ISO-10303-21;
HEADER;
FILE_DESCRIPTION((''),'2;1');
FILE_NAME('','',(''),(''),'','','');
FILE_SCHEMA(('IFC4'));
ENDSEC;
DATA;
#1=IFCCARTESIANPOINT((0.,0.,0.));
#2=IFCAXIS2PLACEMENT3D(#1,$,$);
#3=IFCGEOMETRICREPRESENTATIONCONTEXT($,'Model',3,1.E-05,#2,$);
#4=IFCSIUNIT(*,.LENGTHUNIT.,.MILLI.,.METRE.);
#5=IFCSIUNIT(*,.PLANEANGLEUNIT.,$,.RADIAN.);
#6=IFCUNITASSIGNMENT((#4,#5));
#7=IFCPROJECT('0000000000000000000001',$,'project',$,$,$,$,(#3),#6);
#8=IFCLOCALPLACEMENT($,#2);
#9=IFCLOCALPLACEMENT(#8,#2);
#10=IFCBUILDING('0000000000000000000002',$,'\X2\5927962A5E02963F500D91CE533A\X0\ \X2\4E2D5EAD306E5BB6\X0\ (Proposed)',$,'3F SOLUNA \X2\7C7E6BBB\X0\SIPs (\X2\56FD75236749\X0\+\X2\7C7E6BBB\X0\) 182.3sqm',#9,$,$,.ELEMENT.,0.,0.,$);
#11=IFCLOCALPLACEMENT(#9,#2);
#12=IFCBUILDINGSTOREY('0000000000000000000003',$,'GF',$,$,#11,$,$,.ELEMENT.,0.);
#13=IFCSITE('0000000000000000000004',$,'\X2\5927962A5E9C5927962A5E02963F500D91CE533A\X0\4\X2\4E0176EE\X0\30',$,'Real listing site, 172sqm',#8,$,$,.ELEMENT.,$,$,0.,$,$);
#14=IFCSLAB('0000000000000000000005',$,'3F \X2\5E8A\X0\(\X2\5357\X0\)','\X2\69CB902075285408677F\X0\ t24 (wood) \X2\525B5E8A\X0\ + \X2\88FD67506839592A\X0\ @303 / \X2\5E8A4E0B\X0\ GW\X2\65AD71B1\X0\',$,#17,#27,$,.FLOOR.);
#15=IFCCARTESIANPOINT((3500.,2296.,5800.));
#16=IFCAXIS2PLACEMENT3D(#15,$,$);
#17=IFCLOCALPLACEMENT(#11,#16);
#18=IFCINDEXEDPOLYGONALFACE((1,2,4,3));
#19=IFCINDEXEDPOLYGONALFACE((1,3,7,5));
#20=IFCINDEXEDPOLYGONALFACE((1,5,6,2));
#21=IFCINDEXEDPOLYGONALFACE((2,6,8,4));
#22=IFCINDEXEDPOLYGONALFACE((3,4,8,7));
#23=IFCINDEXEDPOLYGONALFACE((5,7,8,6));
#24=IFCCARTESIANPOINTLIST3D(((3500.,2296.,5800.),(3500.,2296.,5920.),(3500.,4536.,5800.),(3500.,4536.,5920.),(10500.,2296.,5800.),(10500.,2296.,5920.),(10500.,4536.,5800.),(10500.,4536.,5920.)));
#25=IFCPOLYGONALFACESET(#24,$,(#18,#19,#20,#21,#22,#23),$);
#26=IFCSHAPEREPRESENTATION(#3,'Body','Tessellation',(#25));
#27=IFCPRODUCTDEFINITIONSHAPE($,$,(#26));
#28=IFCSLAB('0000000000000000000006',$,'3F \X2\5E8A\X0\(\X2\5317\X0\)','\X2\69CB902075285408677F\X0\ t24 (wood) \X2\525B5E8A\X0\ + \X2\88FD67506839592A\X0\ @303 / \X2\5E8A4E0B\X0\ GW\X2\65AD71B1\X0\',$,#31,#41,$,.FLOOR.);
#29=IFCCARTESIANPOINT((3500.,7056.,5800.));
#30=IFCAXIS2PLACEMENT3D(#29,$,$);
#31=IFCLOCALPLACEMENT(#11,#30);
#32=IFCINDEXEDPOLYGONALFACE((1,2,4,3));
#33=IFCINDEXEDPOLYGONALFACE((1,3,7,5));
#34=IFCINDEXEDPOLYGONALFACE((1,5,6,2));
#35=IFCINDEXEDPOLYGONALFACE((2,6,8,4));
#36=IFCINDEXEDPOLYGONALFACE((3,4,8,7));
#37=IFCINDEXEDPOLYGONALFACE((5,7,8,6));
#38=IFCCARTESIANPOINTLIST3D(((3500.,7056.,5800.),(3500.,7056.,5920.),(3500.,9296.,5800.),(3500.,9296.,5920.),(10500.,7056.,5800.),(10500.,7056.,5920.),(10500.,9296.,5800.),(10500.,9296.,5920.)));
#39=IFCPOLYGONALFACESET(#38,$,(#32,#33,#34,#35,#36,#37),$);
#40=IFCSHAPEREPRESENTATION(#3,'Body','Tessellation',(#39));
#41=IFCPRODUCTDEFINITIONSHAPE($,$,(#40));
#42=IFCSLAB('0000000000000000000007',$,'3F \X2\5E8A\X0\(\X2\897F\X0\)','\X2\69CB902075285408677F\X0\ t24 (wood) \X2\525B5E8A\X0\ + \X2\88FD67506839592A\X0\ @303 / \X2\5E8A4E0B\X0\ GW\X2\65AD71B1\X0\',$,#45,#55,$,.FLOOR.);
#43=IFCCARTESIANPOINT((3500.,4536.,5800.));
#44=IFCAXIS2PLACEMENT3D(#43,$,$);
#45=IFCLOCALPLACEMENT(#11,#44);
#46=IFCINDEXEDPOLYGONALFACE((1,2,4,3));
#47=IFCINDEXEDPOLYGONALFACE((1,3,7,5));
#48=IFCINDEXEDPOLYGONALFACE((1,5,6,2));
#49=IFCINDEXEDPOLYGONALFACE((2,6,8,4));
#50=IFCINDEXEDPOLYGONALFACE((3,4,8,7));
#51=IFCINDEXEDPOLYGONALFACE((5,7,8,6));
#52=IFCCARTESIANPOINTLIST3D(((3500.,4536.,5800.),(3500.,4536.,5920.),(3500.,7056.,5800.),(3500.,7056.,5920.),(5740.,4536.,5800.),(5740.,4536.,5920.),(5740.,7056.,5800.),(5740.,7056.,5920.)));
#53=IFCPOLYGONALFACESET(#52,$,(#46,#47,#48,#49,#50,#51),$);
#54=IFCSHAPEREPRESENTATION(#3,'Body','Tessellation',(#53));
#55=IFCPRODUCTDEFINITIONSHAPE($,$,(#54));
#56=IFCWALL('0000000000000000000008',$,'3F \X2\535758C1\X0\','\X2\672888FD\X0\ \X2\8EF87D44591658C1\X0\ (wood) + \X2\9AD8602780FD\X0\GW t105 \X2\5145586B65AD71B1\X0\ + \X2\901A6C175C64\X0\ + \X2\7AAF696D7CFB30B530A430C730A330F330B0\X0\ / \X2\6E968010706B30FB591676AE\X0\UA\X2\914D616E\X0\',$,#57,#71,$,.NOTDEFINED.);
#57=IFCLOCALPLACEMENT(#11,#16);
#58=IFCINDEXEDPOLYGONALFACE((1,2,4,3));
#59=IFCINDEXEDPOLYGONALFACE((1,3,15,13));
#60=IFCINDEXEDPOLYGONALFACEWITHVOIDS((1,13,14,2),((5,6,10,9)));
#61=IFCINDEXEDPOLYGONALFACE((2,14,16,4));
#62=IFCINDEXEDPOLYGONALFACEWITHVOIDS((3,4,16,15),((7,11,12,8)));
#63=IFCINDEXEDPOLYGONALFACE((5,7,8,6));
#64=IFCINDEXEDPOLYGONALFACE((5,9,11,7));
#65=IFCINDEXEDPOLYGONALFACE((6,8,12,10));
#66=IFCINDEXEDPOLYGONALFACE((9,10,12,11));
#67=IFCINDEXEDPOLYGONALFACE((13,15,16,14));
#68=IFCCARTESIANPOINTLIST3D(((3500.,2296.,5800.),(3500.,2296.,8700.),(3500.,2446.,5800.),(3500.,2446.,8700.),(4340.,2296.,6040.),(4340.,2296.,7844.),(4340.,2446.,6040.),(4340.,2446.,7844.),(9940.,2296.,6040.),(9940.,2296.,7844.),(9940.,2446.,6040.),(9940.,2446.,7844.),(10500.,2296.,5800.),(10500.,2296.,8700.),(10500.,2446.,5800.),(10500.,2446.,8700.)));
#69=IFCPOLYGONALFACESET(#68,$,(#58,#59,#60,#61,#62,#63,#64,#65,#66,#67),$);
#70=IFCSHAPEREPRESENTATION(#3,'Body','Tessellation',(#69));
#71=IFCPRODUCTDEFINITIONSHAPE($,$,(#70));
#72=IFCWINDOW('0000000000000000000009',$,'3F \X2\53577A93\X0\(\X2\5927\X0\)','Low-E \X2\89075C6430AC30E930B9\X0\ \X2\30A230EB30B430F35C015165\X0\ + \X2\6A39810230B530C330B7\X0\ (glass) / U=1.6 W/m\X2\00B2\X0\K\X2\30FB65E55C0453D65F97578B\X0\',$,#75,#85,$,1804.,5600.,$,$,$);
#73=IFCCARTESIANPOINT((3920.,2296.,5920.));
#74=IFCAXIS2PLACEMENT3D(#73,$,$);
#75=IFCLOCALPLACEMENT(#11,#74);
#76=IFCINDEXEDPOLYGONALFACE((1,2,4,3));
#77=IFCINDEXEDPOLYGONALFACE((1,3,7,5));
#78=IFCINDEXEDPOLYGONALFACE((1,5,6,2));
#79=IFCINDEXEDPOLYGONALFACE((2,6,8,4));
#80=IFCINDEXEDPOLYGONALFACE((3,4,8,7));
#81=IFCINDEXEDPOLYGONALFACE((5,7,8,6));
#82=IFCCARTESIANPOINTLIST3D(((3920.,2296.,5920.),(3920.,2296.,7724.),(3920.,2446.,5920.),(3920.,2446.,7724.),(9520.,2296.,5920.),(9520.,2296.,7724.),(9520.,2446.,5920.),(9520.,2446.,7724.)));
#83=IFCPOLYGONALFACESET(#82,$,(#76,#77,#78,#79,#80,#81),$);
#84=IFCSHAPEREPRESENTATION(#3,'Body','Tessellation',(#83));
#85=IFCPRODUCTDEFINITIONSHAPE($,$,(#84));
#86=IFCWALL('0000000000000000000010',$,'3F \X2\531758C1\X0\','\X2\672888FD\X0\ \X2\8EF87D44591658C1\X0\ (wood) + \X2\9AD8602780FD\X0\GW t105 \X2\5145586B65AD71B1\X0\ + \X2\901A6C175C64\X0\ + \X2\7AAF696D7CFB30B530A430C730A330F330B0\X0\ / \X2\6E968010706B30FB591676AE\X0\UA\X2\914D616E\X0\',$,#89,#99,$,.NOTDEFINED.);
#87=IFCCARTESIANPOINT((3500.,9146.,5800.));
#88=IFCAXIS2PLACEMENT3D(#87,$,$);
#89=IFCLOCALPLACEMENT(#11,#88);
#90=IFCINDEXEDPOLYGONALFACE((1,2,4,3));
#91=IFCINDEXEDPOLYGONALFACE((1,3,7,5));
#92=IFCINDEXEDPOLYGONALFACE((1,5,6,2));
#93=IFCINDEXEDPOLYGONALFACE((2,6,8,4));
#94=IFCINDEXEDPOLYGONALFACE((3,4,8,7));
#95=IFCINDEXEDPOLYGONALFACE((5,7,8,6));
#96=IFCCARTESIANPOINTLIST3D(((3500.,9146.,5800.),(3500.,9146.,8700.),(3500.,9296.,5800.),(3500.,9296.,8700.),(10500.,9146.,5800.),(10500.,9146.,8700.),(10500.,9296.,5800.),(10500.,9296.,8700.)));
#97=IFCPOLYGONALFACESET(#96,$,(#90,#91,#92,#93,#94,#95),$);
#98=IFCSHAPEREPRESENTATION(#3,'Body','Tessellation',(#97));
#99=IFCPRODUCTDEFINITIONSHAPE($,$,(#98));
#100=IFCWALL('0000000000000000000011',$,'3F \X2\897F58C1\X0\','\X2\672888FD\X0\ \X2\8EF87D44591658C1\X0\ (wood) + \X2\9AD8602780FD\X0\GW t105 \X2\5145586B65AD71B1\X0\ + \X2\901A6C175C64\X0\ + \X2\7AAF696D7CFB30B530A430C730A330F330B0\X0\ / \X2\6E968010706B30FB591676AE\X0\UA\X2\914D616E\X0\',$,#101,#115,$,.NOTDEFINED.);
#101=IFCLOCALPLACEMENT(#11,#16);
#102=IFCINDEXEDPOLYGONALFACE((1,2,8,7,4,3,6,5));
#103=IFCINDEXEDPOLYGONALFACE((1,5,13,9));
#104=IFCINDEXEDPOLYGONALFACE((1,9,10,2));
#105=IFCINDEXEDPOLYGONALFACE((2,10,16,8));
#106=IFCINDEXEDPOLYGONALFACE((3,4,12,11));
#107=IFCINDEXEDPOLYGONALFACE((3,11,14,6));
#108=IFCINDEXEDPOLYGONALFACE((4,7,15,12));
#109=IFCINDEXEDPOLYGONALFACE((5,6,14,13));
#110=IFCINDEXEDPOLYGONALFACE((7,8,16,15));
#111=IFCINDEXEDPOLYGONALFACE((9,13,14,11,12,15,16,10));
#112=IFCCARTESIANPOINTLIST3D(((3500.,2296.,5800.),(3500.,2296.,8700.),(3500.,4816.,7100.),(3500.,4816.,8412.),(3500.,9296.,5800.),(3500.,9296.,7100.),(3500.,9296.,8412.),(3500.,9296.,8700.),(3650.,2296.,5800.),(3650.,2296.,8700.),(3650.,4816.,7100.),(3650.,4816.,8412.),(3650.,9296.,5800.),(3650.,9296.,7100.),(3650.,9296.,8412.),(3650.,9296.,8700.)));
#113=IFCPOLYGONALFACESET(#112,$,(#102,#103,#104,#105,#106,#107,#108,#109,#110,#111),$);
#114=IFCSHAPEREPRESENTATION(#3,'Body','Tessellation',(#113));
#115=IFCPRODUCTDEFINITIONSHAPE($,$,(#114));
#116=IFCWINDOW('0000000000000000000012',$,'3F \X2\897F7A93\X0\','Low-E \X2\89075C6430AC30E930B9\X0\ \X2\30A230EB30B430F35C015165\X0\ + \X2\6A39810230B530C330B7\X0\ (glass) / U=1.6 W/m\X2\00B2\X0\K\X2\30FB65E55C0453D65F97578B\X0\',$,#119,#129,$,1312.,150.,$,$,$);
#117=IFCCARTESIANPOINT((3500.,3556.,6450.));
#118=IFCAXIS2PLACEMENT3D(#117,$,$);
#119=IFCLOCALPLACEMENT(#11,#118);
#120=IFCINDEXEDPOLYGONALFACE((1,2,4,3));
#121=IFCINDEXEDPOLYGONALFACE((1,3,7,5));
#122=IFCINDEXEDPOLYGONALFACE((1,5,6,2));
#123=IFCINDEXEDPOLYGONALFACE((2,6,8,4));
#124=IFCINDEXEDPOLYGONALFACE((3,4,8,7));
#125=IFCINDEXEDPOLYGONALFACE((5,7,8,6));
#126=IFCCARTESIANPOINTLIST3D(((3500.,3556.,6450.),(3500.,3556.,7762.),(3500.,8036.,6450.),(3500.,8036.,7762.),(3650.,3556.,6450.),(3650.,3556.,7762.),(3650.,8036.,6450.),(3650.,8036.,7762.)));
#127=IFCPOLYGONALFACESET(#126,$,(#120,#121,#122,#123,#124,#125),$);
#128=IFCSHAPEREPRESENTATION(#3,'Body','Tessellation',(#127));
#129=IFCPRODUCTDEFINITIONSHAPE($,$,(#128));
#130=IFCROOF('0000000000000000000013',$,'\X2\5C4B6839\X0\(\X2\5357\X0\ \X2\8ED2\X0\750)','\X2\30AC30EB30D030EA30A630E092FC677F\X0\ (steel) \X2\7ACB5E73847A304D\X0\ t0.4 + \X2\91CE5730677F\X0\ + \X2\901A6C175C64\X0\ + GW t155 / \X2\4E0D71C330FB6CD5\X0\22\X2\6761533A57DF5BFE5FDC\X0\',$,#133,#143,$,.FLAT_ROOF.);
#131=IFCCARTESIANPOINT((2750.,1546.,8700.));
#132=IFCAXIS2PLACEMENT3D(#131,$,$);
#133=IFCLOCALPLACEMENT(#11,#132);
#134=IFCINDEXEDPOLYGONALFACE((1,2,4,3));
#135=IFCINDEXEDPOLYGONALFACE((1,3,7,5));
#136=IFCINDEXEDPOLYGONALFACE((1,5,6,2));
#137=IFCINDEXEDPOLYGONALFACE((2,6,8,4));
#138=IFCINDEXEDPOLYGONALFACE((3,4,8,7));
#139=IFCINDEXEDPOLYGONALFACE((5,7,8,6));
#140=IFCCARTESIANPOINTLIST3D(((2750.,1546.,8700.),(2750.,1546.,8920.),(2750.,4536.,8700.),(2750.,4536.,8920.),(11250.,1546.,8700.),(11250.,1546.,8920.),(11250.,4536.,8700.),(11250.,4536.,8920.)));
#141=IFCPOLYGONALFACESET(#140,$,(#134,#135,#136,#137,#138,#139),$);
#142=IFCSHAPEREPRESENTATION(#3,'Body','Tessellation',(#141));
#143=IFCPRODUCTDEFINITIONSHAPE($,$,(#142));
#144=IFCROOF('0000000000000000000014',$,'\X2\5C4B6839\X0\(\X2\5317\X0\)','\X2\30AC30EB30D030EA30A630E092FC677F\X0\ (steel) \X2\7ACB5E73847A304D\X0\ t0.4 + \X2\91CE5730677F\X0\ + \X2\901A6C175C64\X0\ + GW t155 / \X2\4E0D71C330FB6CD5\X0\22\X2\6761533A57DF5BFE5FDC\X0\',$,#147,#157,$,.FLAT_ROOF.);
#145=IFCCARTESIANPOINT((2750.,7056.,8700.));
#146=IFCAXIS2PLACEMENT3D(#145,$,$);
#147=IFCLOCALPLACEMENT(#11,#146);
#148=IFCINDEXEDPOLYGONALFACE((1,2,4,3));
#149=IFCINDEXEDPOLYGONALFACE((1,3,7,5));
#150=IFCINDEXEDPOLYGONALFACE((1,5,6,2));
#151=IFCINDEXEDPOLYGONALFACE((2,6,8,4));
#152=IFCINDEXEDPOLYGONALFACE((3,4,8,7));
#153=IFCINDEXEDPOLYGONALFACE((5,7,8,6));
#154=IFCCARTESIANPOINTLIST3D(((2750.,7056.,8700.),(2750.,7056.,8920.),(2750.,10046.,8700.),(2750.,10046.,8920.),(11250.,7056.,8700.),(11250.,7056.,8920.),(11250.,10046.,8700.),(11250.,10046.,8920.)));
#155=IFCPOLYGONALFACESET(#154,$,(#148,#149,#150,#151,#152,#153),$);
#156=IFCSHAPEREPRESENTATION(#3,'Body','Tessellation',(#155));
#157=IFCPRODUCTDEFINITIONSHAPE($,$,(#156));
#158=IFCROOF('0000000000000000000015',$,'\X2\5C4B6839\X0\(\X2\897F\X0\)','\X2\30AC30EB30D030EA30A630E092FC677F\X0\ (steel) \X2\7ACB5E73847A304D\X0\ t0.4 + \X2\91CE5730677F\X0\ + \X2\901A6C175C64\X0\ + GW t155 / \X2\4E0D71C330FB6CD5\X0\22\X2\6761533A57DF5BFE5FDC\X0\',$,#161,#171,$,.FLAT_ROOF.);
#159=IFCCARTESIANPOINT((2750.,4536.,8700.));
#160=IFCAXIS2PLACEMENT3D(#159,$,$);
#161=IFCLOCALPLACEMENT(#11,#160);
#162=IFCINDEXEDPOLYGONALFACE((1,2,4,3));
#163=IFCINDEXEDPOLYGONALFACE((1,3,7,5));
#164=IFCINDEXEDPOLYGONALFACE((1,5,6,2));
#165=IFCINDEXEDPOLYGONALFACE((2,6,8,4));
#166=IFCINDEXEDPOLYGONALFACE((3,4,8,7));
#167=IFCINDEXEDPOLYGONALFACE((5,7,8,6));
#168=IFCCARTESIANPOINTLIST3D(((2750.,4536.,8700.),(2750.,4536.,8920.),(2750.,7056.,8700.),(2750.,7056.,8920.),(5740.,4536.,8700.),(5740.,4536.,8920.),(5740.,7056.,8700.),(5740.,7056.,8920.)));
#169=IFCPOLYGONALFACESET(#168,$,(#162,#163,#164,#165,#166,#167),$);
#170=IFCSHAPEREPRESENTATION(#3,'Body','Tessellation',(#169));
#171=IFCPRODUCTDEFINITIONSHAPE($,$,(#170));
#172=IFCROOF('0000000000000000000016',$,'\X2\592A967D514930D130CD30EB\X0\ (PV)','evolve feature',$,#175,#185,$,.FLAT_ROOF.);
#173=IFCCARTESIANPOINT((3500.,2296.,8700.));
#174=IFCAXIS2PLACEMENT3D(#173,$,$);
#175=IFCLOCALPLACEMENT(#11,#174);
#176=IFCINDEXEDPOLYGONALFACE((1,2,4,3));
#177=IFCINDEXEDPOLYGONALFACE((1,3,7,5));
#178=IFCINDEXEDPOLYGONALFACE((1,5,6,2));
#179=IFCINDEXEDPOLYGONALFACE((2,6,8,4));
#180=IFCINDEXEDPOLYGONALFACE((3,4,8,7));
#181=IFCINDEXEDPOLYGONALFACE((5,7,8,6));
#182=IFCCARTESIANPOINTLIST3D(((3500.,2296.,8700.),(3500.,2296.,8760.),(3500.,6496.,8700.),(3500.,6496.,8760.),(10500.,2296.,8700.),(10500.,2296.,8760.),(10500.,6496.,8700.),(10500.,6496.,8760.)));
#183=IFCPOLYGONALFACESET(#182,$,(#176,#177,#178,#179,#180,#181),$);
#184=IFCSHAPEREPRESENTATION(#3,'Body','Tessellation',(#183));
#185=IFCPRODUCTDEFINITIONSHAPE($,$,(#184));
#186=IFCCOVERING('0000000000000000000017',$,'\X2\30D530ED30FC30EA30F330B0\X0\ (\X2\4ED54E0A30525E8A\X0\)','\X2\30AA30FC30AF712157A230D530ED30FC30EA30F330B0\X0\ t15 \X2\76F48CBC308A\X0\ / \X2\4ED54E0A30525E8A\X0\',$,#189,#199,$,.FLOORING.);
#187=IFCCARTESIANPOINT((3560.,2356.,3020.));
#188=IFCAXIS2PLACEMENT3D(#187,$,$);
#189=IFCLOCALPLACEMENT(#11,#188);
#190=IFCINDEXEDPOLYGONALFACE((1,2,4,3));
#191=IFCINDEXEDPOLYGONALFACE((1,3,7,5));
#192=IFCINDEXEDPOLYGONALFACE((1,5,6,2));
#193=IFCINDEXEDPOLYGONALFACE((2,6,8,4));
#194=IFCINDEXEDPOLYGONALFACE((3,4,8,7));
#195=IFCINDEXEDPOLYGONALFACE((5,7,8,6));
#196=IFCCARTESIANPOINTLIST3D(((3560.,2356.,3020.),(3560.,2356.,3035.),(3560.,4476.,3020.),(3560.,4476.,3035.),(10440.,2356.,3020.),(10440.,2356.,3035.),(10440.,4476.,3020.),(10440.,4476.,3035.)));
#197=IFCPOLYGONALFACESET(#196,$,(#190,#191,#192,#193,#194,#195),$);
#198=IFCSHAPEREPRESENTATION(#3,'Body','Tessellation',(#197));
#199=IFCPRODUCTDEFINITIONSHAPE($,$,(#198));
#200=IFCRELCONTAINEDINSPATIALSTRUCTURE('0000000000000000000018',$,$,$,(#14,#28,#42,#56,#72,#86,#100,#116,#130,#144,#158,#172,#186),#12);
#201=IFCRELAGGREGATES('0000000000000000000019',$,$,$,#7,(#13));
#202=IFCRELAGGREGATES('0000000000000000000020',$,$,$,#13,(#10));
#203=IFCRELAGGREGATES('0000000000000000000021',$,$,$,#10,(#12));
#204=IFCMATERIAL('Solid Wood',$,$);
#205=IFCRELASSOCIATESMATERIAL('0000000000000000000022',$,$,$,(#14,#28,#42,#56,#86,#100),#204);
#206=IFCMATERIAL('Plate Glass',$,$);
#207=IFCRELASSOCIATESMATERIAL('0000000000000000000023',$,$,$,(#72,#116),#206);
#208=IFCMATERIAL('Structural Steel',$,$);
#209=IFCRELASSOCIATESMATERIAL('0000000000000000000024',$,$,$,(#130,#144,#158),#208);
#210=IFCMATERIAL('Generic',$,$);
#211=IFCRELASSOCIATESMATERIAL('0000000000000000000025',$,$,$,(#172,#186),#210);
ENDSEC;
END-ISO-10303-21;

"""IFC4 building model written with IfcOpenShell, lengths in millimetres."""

from ifc_helpers import new_model, si_unit, frame, frame_2d, origin, place, context, project, spatial, rectangle, extrude, material, element, fill, save


model = new_model("IFC4")

# Units and contexts
model_context = context("Model", 3, precision=1e-05, world=origin())
ifc_project = project(units=[si_unit("LENGTHUNIT", "METRE", prefix="MILLI"), si_unit("PLANEANGLEUNIT", "RADIAN")], contexts=[model_context])

# Site, building, storey
site_placement = place(None, origin())
site = spatial("IfcSite", under=ifc_project, at=site_placement, Name="大阪府大阪市阿倍野区4丁目30", ObjectType="Real listing site, 172sqm", CompositionType="ELEMENT", RefElevation=0.0)
building_placement = place(site_placement, origin())
building = spatial("IfcBuilding", under=site, at=building_placement, Name="大阪市阿倍野区 中庭の家 (Proposed)", ObjectType="3F SOLUNA 籾殻SIPs (国産杉+籾殻) 182.3sqm", CompositionType="ELEMENT", ElevationOfRefHeight=0.0, ElevationOfTerrain=0.0)
storey_placement = place(building_placement, origin())
storey = spatial("IfcBuildingStorey", under=building, at=storey_placement, Name="GF", CompositionType="ELEMENT", Elevation=0.0)

# Slabs
ifc_material_1 = material(Name="Solid Wood")
slab_1_placement = place(storey_placement, frame((3500.0, 2296.0, 5800.0)))
element("IfcSlab", 1, at=slab_1_placement, inside=storey, material=ifc_material_1, Name="3F 床(南)", Description="構造用合板 t24 (wood) 剛床 + 製材根太 @303 / 床下 GW断熱", PredefinedType="FLOOR", context=model_context, shape_type="SweptSolid", body=[
    extrude(rectangle(XDim=7000.0, YDim=2240.0, at=frame_2d((3500.0, 1120.0))), frame((3500.0, 2296.0, 5800.0)), (0.0, 0.0, 1.0), 120.0),
])
slab_2_placement = place(storey_placement, frame((3500.0, 7056.0, 5800.0)))
element("IfcSlab", 2, at=slab_2_placement, inside=storey, material=ifc_material_1, Name="3F 床(北)", Description="構造用合板 t24 (wood) 剛床 + 製材根太 @303 / 床下 GW断熱", PredefinedType="FLOOR", context=model_context, shape_type="SweptSolid", body=[
    extrude(rectangle(XDim=7000.0, YDim=2240.0, at=frame_2d((3500.0, 1120.0))), frame((3500.0, 7056.0, 5800.0)), (0.0, 0.0, 1.0), 120.0),
])
slab_3_placement = place(storey_placement, frame((3500.0, 4536.0, 5800.0)))
element("IfcSlab", 3, at=slab_3_placement, inside=storey, material=ifc_material_1, Name="3F 床(西)", Description="構造用合板 t24 (wood) 剛床 + 製材根太 @303 / 床下 GW断熱", PredefinedType="FLOOR", context=model_context, shape_type="SweptSolid", body=[
    extrude(rectangle(XDim=2240.0, YDim=2520.0, at=frame_2d((1120.0, 1260.0))), frame((3500.0, 4536.0, 5800.0)), (0.0, 0.0, 1.0), 120.0),
])

# Wall, opening, window
wall_1_placement = place(storey_placement, frame((3500.0, 2296.0, 5800.0)))
wall_1 = element("IfcWall", 4, at=wall_1_placement, inside=storey, material=ifc_material_1, Name="3F 南壁", Description="木製 軸組外壁 (wood) + 高性能GW t105 充填断熱 + 通気層 + 窯業系サイディング / 準耐火・外皮UA配慮", PredefinedType="NOTDEFINED", context=model_context, shape_type="SweptSolid", body=[
    extrude(rectangle(XDim=7000.0, YDim=150.0, at=frame_2d((3500.0, 75.0))), frame((3500.0, 2296.0, 5800.0)), (0.0, 0.0, 1.0), 2900.0),
])
opening_1_placement = place(storey_placement, frame((3920.0, 2296.0, 5920.0)))
opening_1 = element("IfcOpeningElement", 5, at=opening_1_placement, cuts=wall_1, PredefinedType="NOTDEFINED", context=model_context, shape_type="SweptSolid", body=[
    extrude(rectangle(XDim=5600.0, YDim=150.0, at=frame_2d((2800.0, 75.0))), frame((3920.0, 2296.0, 5920.0)), (0.0, 0.0, 1.0), 1804.0),
])
ifc_material_2 = material(Name="Plate Glass")
window_1_placement = place(storey_placement, frame((3920.0, 2296.0, 5920.0)))
window_1 = element("IfcWindow", 6, at=window_1_placement, inside=storey, material=ifc_material_2, Name="3F 南窓(大)", Description="Low-E 複層ガラス アルゴン封入 + 樹脂サッシ (glass) / U=1.6 W/m²K・日射取得型", OverallHeight=1804.0, OverallWidth=5600.0, context=model_context, shape_type="SweptSolid", body=[
    extrude(rectangle(XDim=5600.0, YDim=150.0, at=frame_2d((2800.0, 75.0))), frame((3920.0, 2296.0, 5920.0)), (0.0, 0.0, 1.0), 1804.0),
])
fill(opening_1, window_1)

# Wall
wall_2_placement = place(storey_placement, frame((3500.0, 9146.0, 5800.0)))
element("IfcWall", 7, at=wall_2_placement, inside=storey, material=ifc_material_1, Name="3F 北壁", Description="木製 軸組外壁 (wood) + 高性能GW t105 充填断熱 + 通気層 + 窯業系サイディング / 準耐火・外皮UA配慮", PredefinedType="NOTDEFINED", context=model_context, shape_type="SweptSolid", body=[
    extrude(rectangle(XDim=7000.0, YDim=150.0, at=frame_2d((3500.0, 75.0))), frame((3500.0, 9146.0, 5800.0)), (0.0, 0.0, 1.0), 2900.0),
])

# Wall, opening, window
wall_3_placement = place(storey_placement, frame((3500.0, 2296.0, 5800.0)))
wall_3 = element("IfcWall", 8, at=wall_3_placement, inside=storey, material=ifc_material_1, Name="3F 西壁", Description="木製 軸組外壁 (wood) + 高性能GW t105 充填断熱 + 通気層 + 窯業系サイディング / 準耐火・外皮UA配慮", PredefinedType="NOTDEFINED", context=model_context, shape_type="SweptSolid", body=[
    extrude(rectangle(XDim=150.0, YDim=7000.0, at=frame_2d((75.0, 3500.0))), frame((3500.0, 2296.0, 5800.0)), (0.0, 0.0, 1.0), 2900.0),
])
opening_2_placement = place(storey_placement, frame((3500.0, 3556.0, 6450.0)))
opening_2 = element("IfcOpeningElement", 9, at=opening_2_placement, cuts=wall_3, PredefinedType="NOTDEFINED", context=model_context, shape_type="SweptSolid", body=[
    extrude(rectangle(XDim=150.0, YDim=4480.0, at=frame_2d((75.0, 2240.0))), frame((3500.0, 3556.0, 6450.0)), (0.0, 0.0, 1.0), 1312.0),
])
window_2_placement = place(storey_placement, frame((3500.0, 3556.0, 6450.0)))
window_2 = element("IfcWindow", 10, at=window_2_placement, inside=storey, material=ifc_material_2, Name="3F 西窓", Description="Low-E 複層ガラス アルゴン封入 + 樹脂サッシ (glass) / U=1.6 W/m²K・日射取得型", OverallHeight=1312.0, OverallWidth=150.0, context=model_context, shape_type="SweptSolid", body=[
    extrude(rectangle(XDim=150.0, YDim=4480.0, at=frame_2d((75.0, 2240.0))), frame((3500.0, 3556.0, 6450.0)), (0.0, 0.0, 1.0), 1312.0),
])
fill(opening_2, window_2)

# Roofs
ifc_material_3 = material(Name="Structural Steel")
roof_1_placement = place(storey_placement, frame((2750.0, 1546.0, 8700.0)))
element("IfcRoof", 11, at=roof_1_placement, inside=storey, material=ifc_material_3, Name="屋根(南 軒750)", Description="ガルバリウム鋼板 (steel) 立平葺き t0.4 + 野地板 + 通気層 + GW t155 / 不燃・法22条区域対応", PredefinedType="FLAT_ROOF", context=model_context, shape_type="SweptSolid", body=[
    extrude(rectangle(XDim=8500.0, YDim=2990.0, at=frame_2d((4250.0, 1495.0))), frame((2750.0, 1546.0, 8700.0)), (0.0, 0.0, 1.0), 220.0),
])
roof_2_placement = place(storey_placement, frame((2750.0, 7056.0, 8700.0)))
element("IfcRoof", 12, at=roof_2_placement, inside=storey, material=ifc_material_3, Name="屋根(北)", Description="ガルバリウム鋼板 (steel) 立平葺き t0.4 + 野地板 + 通気層 + GW t155 / 不燃・法22条区域対応", PredefinedType="FLAT_ROOF", context=model_context, shape_type="SweptSolid", body=[
    extrude(rectangle(XDim=8500.0, YDim=2990.0, at=frame_2d((4250.0, 1495.0))), frame((2750.0, 7056.0, 8700.0)), (0.0, 0.0, 1.0), 220.0),
])
roof_3_placement = place(storey_placement, frame((2750.0, 4536.0, 8700.0)))
element("IfcRoof", 13, at=roof_3_placement, inside=storey, material=ifc_material_3, Name="屋根(西)", Description="ガルバリウム鋼板 (steel) 立平葺き t0.4 + 野地板 + 通気層 + GW t155 / 不燃・法22条区域対応", PredefinedType="FLAT_ROOF", context=model_context, shape_type="SweptSolid", body=[
    extrude(rectangle(XDim=2990.0, YDim=2520.0, at=frame_2d((1495.0, 1260.0))), frame((2750.0, 4536.0, 8700.0)), (0.0, 0.0, 1.0), 220.0),
])
ifc_material_4 = material(Name="Generic")
roof_4_placement = place(storey_placement, frame((3500.0, 2296.0, 8700.0)))
element("IfcRoof", 14, at=roof_4_placement, inside=storey, material=ifc_material_4, Name="太陽光パネル (PV)", Description="evolve feature", PredefinedType="FLAT_ROOF", context=model_context, shape_type="SweptSolid", body=[
    extrude(rectangle(XDim=7000.0, YDim=4200.0, at=frame_2d((3500.0, 2100.0))), frame((3500.0, 2296.0, 8700.0)), (0.0, 0.0, 1.0), 60.0),
])

# Covering
covering_1_placement = place(storey_placement, frame((3560.0, 2356.0, 3020.0)))
element("IfcCovering", 15, at=covering_1_placement, inside=storey, material=ifc_material_4, Name="フローリング (仕上げ床)", Description="オーク無垢フローリング t15 直貼り / 仕上げ床", PredefinedType="FLOORING", context=model_context, shape_type="SweptSolid", body=[
    extrude(rectangle(XDim=6880.0, YDim=2120.0, at=frame_2d((3440.0, 1060.0))), frame((3560.0, 2356.0, 3020.0)), (0.0, 0.0, 1.0), 15.0),
])

save(model, "model.ifc")
